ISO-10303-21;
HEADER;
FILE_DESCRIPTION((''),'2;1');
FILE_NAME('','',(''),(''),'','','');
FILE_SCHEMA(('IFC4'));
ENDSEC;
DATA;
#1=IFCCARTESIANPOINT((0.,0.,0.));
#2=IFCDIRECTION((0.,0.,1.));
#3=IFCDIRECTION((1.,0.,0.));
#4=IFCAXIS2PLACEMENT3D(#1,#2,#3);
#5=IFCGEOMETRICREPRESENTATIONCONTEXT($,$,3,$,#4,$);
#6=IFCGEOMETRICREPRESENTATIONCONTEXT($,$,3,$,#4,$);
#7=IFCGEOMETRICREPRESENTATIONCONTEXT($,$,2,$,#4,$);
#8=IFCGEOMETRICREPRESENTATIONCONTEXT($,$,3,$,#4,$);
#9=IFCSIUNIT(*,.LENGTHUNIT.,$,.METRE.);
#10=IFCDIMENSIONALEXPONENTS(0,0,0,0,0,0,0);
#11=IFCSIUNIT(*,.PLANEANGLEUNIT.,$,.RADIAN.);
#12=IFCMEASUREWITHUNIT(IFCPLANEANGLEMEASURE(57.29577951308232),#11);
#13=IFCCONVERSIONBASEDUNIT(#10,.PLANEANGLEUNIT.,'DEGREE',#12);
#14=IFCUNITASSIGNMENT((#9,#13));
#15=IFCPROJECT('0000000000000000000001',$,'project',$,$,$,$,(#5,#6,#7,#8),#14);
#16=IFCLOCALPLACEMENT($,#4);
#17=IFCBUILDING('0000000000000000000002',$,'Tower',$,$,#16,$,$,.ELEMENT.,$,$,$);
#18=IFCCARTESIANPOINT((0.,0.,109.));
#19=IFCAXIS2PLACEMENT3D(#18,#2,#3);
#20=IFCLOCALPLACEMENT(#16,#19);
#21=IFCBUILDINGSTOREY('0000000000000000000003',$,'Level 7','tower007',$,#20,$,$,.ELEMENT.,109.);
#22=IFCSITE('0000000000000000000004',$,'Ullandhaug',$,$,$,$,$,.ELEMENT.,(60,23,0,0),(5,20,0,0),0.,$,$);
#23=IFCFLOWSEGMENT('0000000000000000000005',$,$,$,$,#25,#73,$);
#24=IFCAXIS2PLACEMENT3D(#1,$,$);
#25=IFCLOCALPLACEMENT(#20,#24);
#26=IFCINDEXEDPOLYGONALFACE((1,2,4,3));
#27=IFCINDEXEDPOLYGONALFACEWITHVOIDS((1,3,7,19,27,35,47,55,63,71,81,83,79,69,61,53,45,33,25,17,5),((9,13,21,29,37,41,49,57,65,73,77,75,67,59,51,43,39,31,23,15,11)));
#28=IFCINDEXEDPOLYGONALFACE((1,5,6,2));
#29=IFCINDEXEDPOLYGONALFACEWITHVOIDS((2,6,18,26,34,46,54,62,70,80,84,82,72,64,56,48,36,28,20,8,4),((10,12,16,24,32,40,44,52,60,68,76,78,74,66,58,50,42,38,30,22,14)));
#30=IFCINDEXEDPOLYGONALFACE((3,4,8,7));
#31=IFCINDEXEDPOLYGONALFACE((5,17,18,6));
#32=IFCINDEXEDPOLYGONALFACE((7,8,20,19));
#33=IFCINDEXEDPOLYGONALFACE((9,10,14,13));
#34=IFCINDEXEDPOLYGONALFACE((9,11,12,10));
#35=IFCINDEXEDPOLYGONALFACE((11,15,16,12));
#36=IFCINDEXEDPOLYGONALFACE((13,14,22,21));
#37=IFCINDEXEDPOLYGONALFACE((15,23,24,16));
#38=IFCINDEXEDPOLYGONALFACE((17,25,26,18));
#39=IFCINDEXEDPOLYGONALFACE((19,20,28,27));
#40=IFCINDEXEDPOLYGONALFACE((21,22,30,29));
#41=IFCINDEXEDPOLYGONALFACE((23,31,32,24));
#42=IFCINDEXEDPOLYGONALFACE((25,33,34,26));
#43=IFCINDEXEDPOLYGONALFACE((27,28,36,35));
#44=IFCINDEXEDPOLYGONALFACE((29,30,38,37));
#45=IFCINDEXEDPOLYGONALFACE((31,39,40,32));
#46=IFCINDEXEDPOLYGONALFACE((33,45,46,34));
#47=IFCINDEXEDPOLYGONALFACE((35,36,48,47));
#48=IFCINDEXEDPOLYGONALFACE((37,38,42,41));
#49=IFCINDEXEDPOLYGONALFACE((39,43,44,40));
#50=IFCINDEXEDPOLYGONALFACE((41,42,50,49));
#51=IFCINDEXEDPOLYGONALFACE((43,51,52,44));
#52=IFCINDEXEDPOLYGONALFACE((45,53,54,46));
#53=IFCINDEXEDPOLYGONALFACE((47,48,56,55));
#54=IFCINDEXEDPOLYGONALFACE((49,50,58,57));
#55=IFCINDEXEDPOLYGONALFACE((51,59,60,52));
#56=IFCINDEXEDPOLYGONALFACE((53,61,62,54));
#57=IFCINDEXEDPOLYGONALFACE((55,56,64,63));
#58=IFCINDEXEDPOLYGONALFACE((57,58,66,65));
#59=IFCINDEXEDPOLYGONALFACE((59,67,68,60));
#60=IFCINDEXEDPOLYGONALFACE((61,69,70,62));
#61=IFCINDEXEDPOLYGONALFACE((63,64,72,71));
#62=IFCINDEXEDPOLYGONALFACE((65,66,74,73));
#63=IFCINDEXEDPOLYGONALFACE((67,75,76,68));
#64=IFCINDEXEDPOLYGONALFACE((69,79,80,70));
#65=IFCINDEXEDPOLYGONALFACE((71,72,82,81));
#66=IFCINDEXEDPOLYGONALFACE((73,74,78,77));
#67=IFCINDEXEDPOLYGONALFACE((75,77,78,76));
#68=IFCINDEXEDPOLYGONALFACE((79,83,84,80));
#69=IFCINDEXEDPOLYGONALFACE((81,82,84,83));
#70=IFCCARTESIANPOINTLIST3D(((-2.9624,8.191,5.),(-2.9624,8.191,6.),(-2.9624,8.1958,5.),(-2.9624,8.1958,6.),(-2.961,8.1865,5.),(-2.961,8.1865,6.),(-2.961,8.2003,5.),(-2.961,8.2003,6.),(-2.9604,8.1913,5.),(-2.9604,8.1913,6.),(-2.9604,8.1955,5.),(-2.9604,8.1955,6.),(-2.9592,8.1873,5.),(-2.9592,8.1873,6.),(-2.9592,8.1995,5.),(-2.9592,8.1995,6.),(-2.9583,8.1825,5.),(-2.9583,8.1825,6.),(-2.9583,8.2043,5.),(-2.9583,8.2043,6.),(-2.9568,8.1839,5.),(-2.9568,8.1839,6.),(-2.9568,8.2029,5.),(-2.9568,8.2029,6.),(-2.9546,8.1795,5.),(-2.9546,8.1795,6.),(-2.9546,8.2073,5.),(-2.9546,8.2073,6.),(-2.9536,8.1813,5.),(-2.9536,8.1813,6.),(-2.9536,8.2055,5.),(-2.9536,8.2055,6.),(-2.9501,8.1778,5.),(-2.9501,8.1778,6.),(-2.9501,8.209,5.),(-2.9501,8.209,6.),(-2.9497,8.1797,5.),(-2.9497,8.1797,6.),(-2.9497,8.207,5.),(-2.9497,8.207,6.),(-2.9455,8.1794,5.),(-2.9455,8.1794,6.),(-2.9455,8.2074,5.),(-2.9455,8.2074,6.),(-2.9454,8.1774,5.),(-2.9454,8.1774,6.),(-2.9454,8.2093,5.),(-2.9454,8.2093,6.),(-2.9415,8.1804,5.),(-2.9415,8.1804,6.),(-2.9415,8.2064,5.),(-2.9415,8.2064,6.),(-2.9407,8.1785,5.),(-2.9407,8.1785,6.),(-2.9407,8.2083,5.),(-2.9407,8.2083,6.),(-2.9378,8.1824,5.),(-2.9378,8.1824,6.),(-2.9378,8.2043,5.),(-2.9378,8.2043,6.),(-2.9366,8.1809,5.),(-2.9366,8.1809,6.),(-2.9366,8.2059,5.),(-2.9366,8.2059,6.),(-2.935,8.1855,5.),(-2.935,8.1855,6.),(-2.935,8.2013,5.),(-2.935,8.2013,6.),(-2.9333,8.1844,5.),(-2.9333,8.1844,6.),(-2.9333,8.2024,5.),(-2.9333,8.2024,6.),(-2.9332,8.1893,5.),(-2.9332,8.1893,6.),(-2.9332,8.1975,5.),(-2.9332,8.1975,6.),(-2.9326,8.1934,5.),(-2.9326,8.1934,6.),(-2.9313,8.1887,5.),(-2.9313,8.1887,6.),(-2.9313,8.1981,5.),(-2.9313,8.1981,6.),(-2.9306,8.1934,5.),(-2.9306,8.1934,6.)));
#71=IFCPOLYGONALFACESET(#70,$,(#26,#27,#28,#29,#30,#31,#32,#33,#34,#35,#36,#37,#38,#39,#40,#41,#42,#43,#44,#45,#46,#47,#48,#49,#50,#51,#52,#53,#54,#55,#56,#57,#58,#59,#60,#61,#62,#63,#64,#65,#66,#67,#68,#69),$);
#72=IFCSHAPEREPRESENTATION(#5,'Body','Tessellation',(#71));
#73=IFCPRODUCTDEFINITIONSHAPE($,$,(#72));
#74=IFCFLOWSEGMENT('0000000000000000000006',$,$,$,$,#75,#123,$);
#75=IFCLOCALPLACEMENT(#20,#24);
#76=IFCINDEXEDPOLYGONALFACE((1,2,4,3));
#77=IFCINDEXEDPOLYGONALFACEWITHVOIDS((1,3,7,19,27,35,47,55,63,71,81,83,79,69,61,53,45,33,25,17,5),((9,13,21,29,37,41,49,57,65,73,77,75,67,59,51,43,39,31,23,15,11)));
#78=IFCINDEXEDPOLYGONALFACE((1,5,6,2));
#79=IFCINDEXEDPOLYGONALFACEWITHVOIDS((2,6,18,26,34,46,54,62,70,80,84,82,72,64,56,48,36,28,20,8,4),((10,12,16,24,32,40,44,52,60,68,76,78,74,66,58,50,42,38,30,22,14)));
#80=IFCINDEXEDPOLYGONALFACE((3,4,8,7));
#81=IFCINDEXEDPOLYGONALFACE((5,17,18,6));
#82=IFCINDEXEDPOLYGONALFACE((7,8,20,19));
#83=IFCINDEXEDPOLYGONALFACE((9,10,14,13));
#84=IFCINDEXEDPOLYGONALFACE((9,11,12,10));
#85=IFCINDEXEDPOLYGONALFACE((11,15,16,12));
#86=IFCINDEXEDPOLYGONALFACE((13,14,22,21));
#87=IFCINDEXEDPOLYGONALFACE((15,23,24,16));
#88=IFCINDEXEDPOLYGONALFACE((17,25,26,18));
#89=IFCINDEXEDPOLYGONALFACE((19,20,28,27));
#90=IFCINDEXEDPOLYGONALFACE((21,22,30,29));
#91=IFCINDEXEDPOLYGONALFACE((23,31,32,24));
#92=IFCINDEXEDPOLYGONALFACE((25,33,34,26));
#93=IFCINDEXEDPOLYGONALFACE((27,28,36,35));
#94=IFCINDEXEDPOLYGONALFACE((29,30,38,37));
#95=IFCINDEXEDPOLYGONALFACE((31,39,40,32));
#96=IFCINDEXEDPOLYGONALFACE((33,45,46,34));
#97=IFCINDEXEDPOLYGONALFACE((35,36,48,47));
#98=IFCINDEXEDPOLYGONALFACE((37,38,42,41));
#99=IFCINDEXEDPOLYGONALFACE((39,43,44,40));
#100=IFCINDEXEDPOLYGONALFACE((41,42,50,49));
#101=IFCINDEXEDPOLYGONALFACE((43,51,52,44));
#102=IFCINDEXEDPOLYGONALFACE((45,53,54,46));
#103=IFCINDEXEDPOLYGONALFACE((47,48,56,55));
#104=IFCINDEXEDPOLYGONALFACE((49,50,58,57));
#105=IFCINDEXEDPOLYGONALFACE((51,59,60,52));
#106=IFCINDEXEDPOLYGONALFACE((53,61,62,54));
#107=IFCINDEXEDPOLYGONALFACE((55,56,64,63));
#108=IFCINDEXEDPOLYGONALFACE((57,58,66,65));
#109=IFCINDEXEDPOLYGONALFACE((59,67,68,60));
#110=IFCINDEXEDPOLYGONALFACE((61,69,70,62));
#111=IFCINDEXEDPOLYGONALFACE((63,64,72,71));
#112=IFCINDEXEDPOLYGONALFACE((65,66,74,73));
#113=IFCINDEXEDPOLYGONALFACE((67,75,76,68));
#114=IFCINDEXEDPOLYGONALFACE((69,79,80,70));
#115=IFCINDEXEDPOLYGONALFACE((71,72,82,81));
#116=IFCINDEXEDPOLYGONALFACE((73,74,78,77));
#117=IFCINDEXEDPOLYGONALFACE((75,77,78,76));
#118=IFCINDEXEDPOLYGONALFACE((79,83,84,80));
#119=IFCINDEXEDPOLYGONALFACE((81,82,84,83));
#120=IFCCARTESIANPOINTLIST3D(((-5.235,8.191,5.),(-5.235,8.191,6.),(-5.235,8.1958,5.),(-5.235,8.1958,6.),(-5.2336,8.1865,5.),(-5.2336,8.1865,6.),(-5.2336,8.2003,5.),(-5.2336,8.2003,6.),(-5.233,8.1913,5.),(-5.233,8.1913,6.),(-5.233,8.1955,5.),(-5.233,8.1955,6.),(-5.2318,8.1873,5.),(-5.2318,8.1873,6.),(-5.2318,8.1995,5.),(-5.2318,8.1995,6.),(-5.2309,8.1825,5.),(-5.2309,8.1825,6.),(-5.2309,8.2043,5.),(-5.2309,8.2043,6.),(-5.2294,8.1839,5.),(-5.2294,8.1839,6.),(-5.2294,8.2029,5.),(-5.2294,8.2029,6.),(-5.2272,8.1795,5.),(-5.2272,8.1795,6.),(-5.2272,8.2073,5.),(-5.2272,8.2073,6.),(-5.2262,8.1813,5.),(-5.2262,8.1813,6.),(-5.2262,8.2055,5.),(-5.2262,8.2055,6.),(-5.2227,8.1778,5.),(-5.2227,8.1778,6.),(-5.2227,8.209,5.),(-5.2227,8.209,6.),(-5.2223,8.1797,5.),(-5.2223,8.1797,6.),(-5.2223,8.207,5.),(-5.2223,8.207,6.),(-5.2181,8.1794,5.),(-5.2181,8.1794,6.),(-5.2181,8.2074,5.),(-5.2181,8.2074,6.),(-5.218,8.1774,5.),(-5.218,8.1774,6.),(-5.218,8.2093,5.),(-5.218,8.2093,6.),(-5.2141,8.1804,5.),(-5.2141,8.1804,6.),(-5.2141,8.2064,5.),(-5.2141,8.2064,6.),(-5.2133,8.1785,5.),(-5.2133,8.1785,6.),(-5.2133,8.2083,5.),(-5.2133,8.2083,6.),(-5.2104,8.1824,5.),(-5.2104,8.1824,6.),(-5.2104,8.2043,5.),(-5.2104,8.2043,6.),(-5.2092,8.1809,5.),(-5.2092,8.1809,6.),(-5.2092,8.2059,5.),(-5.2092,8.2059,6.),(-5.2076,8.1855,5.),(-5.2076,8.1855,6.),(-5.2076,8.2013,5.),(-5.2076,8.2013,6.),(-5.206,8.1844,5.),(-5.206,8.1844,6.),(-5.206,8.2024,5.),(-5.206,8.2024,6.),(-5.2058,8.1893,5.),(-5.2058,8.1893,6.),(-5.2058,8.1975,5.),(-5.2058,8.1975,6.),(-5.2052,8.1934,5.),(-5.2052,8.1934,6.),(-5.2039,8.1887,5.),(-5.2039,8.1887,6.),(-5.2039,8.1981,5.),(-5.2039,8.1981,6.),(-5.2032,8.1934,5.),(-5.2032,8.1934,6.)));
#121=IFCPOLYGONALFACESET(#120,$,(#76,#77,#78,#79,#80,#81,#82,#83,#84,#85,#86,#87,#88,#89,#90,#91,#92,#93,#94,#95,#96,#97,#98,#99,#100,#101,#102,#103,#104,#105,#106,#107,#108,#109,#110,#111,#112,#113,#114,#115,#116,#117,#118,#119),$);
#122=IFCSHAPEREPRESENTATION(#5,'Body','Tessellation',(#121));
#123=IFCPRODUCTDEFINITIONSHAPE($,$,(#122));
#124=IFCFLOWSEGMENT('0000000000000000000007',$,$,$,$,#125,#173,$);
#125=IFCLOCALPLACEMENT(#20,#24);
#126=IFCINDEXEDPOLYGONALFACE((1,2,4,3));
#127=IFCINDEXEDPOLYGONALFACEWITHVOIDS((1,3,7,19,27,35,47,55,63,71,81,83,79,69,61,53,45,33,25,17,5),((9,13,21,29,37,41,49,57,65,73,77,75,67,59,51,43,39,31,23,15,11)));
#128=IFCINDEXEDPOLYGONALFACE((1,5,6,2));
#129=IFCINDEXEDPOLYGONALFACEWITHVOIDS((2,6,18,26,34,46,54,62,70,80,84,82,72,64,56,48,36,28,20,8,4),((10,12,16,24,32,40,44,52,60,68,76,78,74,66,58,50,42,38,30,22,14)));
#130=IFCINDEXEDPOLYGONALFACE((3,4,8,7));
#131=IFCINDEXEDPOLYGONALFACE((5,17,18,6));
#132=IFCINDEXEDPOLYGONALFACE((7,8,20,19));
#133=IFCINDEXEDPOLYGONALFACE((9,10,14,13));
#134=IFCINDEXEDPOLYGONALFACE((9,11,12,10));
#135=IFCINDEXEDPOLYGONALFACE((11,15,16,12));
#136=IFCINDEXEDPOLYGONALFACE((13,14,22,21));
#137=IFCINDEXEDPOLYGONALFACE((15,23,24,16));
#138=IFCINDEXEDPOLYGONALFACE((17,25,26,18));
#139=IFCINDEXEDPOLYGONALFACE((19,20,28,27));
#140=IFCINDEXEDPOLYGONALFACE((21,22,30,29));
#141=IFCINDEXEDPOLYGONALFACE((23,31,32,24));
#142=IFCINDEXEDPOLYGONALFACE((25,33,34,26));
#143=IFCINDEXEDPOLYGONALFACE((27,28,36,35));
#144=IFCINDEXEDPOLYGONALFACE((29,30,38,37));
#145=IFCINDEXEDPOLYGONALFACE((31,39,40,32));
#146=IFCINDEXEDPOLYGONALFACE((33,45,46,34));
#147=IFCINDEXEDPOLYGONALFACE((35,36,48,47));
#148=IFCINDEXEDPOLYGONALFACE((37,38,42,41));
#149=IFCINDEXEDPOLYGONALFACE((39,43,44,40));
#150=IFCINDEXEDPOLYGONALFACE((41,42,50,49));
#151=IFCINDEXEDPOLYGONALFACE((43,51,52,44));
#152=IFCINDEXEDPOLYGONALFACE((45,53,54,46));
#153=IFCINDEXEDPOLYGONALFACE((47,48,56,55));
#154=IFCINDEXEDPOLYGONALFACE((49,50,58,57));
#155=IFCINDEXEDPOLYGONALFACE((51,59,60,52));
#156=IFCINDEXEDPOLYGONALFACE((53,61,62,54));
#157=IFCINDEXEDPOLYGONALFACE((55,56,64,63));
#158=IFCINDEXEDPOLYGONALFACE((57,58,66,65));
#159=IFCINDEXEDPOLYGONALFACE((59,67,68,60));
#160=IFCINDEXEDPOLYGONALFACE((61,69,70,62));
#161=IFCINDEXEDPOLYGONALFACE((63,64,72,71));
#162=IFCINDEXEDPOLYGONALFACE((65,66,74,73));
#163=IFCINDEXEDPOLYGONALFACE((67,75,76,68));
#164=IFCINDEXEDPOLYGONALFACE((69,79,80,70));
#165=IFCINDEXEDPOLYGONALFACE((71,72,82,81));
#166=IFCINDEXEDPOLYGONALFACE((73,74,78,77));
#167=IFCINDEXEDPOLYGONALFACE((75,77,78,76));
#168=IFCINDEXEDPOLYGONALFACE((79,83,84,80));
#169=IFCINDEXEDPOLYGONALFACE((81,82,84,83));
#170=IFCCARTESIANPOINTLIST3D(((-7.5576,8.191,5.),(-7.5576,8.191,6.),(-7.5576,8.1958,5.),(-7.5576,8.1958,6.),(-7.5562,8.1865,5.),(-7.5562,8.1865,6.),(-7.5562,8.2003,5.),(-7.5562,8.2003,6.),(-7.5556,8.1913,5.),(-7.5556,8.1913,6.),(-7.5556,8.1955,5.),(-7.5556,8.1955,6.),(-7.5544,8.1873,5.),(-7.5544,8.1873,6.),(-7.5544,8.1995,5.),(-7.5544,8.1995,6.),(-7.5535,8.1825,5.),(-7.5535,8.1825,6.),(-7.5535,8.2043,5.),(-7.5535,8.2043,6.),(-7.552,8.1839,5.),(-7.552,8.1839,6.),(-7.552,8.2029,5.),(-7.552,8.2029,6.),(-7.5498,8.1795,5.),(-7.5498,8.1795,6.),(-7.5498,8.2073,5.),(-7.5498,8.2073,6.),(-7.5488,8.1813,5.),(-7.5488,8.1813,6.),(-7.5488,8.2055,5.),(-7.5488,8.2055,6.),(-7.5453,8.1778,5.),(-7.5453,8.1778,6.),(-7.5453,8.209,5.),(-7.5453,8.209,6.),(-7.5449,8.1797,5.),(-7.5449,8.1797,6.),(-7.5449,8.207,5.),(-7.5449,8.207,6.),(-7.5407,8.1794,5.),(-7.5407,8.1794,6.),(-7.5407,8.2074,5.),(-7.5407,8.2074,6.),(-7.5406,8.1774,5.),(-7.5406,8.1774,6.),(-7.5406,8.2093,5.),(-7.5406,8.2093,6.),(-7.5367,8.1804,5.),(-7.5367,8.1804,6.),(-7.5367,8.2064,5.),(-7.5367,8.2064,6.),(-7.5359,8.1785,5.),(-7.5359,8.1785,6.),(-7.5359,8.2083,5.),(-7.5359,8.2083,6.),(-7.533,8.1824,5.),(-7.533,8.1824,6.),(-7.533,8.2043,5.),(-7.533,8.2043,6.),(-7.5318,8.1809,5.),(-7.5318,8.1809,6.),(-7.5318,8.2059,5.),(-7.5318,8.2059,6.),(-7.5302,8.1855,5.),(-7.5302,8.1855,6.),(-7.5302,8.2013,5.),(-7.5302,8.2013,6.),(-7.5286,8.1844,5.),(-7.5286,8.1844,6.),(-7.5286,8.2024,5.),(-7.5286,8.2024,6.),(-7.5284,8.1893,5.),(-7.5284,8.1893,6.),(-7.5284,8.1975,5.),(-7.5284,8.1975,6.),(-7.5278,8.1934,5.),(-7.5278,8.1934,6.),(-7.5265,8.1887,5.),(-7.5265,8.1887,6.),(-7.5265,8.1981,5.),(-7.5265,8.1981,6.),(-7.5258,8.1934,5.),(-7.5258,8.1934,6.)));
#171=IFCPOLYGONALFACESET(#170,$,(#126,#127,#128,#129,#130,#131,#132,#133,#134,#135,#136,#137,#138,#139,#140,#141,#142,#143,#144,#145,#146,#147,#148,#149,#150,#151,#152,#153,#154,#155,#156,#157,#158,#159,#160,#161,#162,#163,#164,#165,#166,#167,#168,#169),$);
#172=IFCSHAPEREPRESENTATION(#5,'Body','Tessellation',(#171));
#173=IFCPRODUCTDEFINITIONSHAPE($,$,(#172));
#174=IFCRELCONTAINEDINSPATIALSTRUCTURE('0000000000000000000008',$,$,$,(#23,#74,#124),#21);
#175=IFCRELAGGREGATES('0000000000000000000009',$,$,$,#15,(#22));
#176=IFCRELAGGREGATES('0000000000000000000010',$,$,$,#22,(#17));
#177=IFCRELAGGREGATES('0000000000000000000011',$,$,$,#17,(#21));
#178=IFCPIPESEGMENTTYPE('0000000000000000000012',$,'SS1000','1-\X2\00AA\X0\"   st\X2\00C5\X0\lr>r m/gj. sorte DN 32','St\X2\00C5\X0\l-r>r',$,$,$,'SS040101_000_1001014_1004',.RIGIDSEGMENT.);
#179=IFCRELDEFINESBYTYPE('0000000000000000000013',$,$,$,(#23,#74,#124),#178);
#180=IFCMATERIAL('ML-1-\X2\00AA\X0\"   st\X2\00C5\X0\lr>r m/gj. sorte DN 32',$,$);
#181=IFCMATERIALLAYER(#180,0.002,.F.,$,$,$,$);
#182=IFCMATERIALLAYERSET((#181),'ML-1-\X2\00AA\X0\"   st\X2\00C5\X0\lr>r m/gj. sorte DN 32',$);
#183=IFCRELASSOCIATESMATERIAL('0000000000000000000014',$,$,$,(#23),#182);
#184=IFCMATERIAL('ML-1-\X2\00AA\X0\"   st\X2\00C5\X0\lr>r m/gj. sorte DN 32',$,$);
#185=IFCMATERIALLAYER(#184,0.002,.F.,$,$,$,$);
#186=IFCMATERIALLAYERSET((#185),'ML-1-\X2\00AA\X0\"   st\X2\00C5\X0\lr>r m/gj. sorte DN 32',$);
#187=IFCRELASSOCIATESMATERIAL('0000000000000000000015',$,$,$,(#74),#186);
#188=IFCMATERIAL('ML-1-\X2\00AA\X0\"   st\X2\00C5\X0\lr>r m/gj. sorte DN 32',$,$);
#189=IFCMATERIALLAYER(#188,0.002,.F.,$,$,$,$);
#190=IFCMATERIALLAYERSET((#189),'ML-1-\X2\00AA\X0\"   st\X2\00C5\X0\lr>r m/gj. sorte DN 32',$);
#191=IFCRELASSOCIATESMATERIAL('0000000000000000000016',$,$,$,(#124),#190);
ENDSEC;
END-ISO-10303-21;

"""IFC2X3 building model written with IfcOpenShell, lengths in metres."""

from ifc_helpers import new_model, entity, si_unit, converted_unit, frame, origin_with_axes, origin_2d_with_axis, place, context, project, spatial, hollow_circle, extrude, material, layer, layer_set, layer_usage, type_object, element, save


model = new_model("IFC2X3")

# Units and contexts
context_of_model_1 = context(None, 3, world=origin_with_axes())
context_of_model_2 = context(None, 3, world=origin_with_axes())
context_of_model_3 = context(None, 2, world=origin_with_axes())
context_of_model_4 = context(None, 3, world=origin_with_axes())
ifc_project = project(units=[si_unit("LENGTHUNIT", "METRE"), converted_unit("PLANEANGLEUNIT", "DEGREE", entity("IfcPlaneAngleMeasure", 57.29577951308232), si_unit("PLANEANGLEUNIT", "RADIAN"), dimensions=[0, 0, 0, 0, 0, 0, 0])], contexts=[context_of_model_1, context_of_model_2, context_of_model_3, context_of_model_4])

# Site, building, storey
site = spatial("IfcSite", under=ifc_project, Name="Ullandhaug", CompositionType="ELEMENT", RefLatitude=(60, 23, 0, 0), RefLongitude=(5, 20, 0, 0), RefElevation=0.0)
building_placement = place(None, origin_with_axes())
building = spatial("IfcBuilding", under=site, at=building_placement, Name="Tower", CompositionType="ELEMENT")
storey_placement = place(building_placement, frame((0.0, 0.0, 109.0), z_axis=(0.0, 0.0, 1.0), x_axis=(1.0, 0.0, 0.0)))
storey = spatial("IfcBuildingStorey", under=building, at=storey_placement, Name="Level 7", Description="tower007", CompositionType="ELEMENT", Elevation=109.0)

# Flow segments
ifc_material_1 = material(Name="ML-1-ª\"   stÅlr>r m/gj. sorte DN 32")
ifc_layer_1 = layer(ifc_material_1, 0.002, ventilated=False)
ifc_layer_set_1 = layer_set([ifc_layer_1], Name="ML-1-ª\"   stÅlr>r m/gj. sorte DN 32")
ifc_layer_usage_1 = layer_usage(ifc_layer_set_1, "AXIS2", "POSITIVE", 0.0)
pipe_segment_type_1 = type_object("IfcPipeSegmentType", Name="SS1000", Description="1-ª\"   stÅlr>r m/gj. sorte DN 32", ApplicableOccurrence="StÅl-r>r", ElementType="SS040101_000_1001014_1004", PredefinedType="RIGIDSEGMENT")
flow_segment_1_placement = place(storey_placement, frame((-2.9466, 8.1934, 5.0), z_axis=(0.0, 0.0, 1.0), x_axis=(1.0, 0.0, 0.0)))
element("IfcFlowSegment", 1, at=flow_segment_1_placement, inside=storey, type_object=pipe_segment_type_1, material=ifc_layer_usage_1, context=context_of_model_1, shape_type="SweptSolid", body=[
    extrude(hollow_circle(Radius=0.016, WallThickness=0.002, at=origin_2d_with_axis()), origin_with_axes(), (0.0, 0.0, 1.0), 1.0),
])
ifc_material_2 = material(Name="ML-1-ª\"   stÅlr>r m/gj. sorte DN 32")
ifc_layer_2 = layer(ifc_material_2, 0.002, ventilated=False)
ifc_layer_set_2 = layer_set([ifc_layer_2], Name="ML-1-ª\"   stÅlr>r m/gj. sorte DN 32")
ifc_layer_usage_2 = layer_usage(ifc_layer_set_2, "AXIS2", "POSITIVE", 0.0)
flow_segment_2_placement = place(storey_placement, frame((-5.2192, 8.1934, 5.0), z_axis=(0.0, 0.0, 1.0), x_axis=(1.0, 0.0, 0.0)))
element("IfcFlowSegment", 2, at=flow_segment_2_placement, inside=storey, type_object=pipe_segment_type_1, material=ifc_layer_usage_2, context=context_of_model_1, shape_type="SweptSolid", body=[
    extrude(hollow_circle(Radius=0.016, WallThickness=0.002, at=origin_2d_with_axis()), origin_with_axes(), (0.0, 0.0, 1.0), 1.0),
])
ifc_material_3 = material(Name="ML-1-ª\"   stÅlr>r m/gj. sorte DN 32")
ifc_layer_3 = layer(ifc_material_3, 0.002, ventilated=False)
ifc_layer_set_3 = layer_set([ifc_layer_3], Name="ML-1-ª\"   stÅlr>r m/gj. sorte DN 32")
ifc_layer_usage_3 = layer_usage(ifc_layer_set_3, "AXIS2", "POSITIVE", 0.0)
flow_segment_3_placement = place(storey_placement, frame((-7.5418, 8.1934, 5.0), z_axis=(0.0, 0.0, 1.0), x_axis=(1.0, 0.0, 0.0)))
element("IfcFlowSegment", 3, at=flow_segment_3_placement, inside=storey, type_object=pipe_segment_type_1, material=ifc_layer_usage_3, context=context_of_model_1, shape_type="SweptSolid", body=[
    extrude(hollow_circle(Radius=0.016, WallThickness=0.002, at=origin_2d_with_axis()), origin_with_axes(), (0.0, 0.0, 1.0), 1.0),
])

save(model, "model.ifc")
